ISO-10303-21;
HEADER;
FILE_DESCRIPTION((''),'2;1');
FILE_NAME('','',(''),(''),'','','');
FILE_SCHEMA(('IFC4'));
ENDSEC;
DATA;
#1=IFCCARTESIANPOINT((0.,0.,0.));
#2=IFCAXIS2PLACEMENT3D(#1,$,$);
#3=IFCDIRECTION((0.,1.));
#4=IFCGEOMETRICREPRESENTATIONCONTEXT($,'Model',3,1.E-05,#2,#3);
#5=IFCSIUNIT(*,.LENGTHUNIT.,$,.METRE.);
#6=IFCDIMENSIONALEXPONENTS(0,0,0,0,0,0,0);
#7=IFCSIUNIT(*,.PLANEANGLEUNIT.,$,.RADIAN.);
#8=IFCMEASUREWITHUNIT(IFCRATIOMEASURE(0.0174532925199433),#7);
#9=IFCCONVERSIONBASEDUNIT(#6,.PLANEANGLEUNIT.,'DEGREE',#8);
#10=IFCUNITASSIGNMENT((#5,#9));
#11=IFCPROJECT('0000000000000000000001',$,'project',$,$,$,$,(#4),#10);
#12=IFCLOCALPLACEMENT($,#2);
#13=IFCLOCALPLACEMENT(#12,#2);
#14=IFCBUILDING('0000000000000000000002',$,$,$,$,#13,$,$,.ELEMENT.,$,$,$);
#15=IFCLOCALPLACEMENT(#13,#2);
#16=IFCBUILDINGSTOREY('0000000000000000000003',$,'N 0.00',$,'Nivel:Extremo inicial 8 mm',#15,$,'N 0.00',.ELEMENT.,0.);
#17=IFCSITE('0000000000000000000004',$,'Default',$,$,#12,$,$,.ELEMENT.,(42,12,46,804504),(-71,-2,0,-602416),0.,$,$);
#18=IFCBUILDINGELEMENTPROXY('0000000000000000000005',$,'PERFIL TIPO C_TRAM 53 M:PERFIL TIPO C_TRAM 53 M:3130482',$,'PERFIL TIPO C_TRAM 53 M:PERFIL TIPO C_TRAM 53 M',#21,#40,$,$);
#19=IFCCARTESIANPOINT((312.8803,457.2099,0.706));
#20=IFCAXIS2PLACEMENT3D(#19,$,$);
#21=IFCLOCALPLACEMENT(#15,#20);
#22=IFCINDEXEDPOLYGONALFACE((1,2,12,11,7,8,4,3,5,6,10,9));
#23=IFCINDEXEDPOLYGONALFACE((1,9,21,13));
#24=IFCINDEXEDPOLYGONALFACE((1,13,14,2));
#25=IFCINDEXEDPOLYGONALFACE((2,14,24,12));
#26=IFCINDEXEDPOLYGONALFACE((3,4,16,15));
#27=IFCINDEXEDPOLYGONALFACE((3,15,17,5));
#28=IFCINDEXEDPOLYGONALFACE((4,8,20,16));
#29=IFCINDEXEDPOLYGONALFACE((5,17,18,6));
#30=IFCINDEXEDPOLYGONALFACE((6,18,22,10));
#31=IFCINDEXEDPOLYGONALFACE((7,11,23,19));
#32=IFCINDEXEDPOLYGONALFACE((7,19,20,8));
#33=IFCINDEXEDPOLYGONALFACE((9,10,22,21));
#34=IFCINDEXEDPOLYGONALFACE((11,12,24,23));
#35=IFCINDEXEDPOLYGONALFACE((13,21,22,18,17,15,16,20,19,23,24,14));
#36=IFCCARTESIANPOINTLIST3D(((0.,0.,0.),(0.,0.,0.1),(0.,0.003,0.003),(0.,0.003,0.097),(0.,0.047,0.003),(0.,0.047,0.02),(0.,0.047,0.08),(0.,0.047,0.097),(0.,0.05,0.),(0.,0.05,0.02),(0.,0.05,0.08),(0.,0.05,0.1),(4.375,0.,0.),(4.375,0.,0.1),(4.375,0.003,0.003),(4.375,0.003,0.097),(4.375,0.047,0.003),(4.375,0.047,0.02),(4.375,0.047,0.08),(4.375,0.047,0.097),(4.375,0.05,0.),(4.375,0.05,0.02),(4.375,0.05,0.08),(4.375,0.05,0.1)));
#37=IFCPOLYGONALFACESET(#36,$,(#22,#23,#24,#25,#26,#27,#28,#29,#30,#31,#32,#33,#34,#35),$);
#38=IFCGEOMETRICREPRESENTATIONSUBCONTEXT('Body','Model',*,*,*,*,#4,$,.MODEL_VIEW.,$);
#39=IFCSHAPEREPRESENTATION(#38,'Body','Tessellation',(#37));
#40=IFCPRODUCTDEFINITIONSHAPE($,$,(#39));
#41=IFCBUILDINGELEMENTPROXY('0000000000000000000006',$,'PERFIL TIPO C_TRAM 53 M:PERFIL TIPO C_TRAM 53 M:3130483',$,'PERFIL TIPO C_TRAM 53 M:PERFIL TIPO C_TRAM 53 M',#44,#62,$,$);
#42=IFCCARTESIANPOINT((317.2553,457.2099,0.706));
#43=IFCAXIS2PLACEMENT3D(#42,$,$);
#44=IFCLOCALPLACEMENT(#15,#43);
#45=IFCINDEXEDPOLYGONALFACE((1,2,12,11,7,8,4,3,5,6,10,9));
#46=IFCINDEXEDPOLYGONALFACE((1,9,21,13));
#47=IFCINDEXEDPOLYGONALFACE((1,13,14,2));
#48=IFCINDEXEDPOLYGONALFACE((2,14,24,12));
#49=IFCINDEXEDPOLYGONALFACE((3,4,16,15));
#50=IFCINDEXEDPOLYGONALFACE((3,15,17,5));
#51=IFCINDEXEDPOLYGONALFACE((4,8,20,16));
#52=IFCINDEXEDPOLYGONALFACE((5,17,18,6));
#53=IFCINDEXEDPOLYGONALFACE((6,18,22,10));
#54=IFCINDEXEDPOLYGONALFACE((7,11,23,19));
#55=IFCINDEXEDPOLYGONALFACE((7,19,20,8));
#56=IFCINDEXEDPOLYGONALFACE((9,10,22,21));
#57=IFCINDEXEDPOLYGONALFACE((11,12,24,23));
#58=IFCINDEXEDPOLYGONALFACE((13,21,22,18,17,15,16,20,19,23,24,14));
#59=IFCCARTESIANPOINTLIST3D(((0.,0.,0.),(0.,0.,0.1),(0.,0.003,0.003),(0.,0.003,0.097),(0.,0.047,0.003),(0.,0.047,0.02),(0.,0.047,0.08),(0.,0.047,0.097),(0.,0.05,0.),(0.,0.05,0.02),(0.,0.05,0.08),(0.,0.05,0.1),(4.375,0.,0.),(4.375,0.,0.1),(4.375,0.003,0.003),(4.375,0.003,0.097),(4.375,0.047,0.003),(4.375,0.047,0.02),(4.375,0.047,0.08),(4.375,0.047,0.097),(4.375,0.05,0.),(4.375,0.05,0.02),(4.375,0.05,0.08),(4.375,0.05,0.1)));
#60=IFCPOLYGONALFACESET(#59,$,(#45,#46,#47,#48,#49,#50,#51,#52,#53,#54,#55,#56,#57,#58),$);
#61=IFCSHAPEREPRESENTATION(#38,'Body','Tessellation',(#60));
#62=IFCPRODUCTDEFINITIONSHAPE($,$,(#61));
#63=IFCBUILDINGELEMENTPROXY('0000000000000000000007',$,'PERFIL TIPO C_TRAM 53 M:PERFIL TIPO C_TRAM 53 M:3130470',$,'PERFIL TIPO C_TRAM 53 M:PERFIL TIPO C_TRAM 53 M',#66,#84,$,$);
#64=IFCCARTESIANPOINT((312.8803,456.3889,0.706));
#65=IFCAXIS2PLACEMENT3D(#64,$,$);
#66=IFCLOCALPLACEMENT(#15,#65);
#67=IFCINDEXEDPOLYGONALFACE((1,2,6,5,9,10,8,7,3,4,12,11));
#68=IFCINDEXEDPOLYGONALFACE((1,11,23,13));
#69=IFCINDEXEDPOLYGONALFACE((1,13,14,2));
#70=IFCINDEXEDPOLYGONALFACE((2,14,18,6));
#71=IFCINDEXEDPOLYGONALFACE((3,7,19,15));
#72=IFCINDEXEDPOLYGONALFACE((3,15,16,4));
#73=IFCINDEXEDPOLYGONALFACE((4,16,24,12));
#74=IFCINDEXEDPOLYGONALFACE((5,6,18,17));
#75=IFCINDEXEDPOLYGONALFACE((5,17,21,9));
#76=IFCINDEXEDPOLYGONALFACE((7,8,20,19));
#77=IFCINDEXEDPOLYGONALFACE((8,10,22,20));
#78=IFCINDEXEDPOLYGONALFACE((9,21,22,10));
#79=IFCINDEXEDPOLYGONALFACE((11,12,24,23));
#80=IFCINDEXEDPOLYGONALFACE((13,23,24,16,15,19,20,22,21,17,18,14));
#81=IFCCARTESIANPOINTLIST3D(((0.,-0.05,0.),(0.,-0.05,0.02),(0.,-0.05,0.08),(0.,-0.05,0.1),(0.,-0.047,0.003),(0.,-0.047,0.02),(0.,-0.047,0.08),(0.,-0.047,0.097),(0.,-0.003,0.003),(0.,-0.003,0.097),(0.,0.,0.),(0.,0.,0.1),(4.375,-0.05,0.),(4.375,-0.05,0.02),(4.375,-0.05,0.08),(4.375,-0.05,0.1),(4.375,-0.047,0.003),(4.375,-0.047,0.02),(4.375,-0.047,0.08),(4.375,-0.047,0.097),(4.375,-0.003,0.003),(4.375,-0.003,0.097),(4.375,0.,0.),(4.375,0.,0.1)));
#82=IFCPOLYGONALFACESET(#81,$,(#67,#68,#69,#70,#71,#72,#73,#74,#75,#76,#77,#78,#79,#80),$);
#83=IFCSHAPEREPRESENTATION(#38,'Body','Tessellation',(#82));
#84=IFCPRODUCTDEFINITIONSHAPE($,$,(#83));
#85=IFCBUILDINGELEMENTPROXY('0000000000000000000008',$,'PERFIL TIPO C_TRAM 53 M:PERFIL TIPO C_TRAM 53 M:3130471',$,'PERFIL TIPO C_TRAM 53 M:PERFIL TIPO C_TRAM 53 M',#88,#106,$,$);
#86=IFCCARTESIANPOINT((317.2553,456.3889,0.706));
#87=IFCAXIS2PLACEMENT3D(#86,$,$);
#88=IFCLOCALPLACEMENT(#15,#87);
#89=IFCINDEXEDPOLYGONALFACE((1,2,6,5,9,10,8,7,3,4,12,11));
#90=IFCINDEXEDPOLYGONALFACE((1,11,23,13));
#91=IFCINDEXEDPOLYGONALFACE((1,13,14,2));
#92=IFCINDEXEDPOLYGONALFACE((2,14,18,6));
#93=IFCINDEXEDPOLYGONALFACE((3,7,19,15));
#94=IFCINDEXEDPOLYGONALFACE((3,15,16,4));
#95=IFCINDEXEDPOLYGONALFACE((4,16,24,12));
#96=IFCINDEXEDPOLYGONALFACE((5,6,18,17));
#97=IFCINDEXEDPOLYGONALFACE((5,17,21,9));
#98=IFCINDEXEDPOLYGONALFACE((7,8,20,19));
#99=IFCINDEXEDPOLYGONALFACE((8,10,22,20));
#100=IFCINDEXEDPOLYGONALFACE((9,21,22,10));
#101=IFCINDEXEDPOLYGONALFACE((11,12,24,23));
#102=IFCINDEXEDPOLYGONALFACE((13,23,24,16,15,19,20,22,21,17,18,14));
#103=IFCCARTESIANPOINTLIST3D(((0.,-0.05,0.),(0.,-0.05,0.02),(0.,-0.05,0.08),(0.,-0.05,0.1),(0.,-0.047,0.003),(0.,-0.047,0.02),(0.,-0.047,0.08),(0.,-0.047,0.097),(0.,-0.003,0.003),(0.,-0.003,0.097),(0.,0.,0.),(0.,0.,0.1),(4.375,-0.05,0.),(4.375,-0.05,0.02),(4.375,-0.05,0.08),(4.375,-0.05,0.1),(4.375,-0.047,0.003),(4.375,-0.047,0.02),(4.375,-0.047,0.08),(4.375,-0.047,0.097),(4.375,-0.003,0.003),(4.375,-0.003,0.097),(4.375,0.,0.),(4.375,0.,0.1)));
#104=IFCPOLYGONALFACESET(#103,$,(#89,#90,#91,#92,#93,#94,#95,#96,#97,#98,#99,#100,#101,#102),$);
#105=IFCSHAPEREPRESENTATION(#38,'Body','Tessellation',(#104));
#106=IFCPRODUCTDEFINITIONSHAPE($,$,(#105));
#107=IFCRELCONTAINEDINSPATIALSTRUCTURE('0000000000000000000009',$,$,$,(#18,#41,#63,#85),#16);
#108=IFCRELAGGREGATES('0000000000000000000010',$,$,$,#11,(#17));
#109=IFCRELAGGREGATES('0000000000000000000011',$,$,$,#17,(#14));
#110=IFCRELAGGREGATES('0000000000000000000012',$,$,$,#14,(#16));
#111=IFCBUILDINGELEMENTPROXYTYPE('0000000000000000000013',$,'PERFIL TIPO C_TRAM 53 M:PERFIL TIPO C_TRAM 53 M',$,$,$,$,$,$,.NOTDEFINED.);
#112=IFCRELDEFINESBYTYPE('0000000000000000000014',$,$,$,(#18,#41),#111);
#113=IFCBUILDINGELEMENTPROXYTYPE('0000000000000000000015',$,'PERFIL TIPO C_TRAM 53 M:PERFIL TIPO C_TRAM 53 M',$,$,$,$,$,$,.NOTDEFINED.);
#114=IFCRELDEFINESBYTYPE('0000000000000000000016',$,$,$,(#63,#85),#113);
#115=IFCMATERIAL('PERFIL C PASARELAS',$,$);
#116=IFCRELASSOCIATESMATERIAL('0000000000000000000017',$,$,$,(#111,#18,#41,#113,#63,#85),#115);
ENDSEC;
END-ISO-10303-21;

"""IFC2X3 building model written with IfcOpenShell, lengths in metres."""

from ifc_helpers import new_model, entity, si_unit, converted_unit, direction, frame, origin, place, context, subcontext, project, spatial, polyline, outline, extrude, source, transform, mapped, material, type_object, type_shapes, element, save


model = new_model("IFC2X3")

# Units and contexts
model_context = context("Model", 3, precision=1e-05, world=origin(), true_north=direction((0.0, 1.0)))
body_context = subcontext(model_context, "Body", "Model", "MODEL_VIEW")
ifc_project = project(units=[si_unit("LENGTHUNIT", "METRE"), converted_unit("PLANEANGLEUNIT", "DEGREE", entity("IfcRatioMeasure", 0.0174532925199433), si_unit("PLANEANGLEUNIT", "RADIAN"), dimensions=[0, 0, 0, 0, 0, 0, 0])], contexts=[model_context])

# Site, building, storey
site_placement = place(None, origin())
site = spatial("IfcSite", under=ifc_project, at=site_placement, Name="Default", CompositionType="ELEMENT", RefLatitude=(42, 12, 46, 804504), RefLongitude=(-71, -2, 0, -602416), RefElevation=0.0)
building_placement = place(site_placement, origin())
building = spatial("IfcBuilding", under=site, at=building_placement, CompositionType="ELEMENT")
storey_placement = place(building_placement, origin())
storey = spatial("IfcBuildingStorey", under=building, at=storey_placement, Name="N 0.00", ObjectType="Nivel:Extremo inicial 8 mm", LongName="N 0.00", CompositionType="ELEMENT", Elevation=0.0)

# Building element proxies
ifc_material_1 = material(Name="PERFIL C PASARELAS")
building_element_proxy_type_1 = type_object("IfcBuildingElementProxyType", Name="PERFIL TIPO C_TRAM 53 M:PERFIL TIPO C_TRAM 53 M", PredefinedType="NOTDEFINED", material=ifc_material_1)
shared_shape_1 = source(origin(), body_context, "Body", "SweptSolid", [
    extrude(outline(polyline([(-0.0172, 0.03), (-0.0142, 0.03), (-0.0142, 0.047), (0.0298, 0.047), (0.0298, -0.047), (-0.0142, -0.047), (-0.0142, -0.03), (-0.0172, -0.03), (-0.0172, -0.05), (0.0328, -0.05), (0.0328, 0.05), (-0.0172, 0.05), (-0.0172, 0.03)])), frame((0.0, 0.0328, 0.05), z_axis=(1.0, 0.0, 0.0), x_axis=(0.0, -1.0, 0.0)), (0.0, 0.0, 1.0), 4.375),
])
type_shapes(building_element_proxy_type_1, [shared_shape_1])
for number, where, name in (
    (1, (312.8803, 457.2099, 0.706), "PERFIL TIPO C_TRAM 53 M:PERFIL TIPO C_TRAM 53 M:3130482"),
    (2, (317.2553, 457.2099, 0.706), "PERFIL TIPO C_TRAM 53 M:PERFIL TIPO C_TRAM 53 M:3130483"),
):
    element("IfcBuildingElementProxy", number, at=place(storey_placement, frame(where)), inside=storey, type_object=building_element_proxy_type_1, material=ifc_material_1, Name=name, ObjectType="PERFIL TIPO C_TRAM 53 M:PERFIL TIPO C_TRAM 53 M", context=body_context, shape_type="MappedRepresentation", body=[
        mapped(shared_shape_1, transform((0.0, 0.0, 0.0), scale=1.0)),
    ])
building_element_proxy_type_2 = type_object("IfcBuildingElementProxyType", Name="PERFIL TIPO C_TRAM 53 M:PERFIL TIPO C_TRAM 53 M", PredefinedType="NOTDEFINED", material=ifc_material_1)
shared_shape_2 = source(origin(), body_context, "Body", "SweptSolid", [
    extrude(outline(polyline([(0.03, -0.0172), (0.05, -0.0172), (0.05, 0.0328), (-0.05, 0.0328), (-0.05, -0.0172), (-0.03, -0.0172), (-0.03, -0.0142), (-0.047, -0.0142), (-0.047, 0.0298), (0.047, 0.0298), (0.047, -0.0142), (0.03, -0.0142), (0.03, -0.0172)])), frame((0.0, -0.0328, 0.05), z_axis=(1.0, 0.0, 0.0), x_axis=(0.0, 0.0, -1.0)), (0.0, 0.0, 1.0), 4.375),
])
type_shapes(building_element_proxy_type_2, [shared_shape_2])
for number, where, name in (
    (3, (312.8803, 456.3889, 0.706), "PERFIL TIPO C_TRAM 53 M:PERFIL TIPO C_TRAM 53 M:3130470"),
    (4, (317.2553, 456.3889, 0.706), "PERFIL TIPO C_TRAM 53 M:PERFIL TIPO C_TRAM 53 M:3130471"),
):
    element("IfcBuildingElementProxy", number, at=place(storey_placement, frame(where)), inside=storey, type_object=building_element_proxy_type_2, material=ifc_material_1, Name=name, ObjectType="PERFIL TIPO C_TRAM 53 M:PERFIL TIPO C_TRAM 53 M", context=body_context, shape_type="MappedRepresentation", body=[
        mapped(shared_shape_2, transform((0.0, 0.0, 0.0), scale=1.0)),
    ])

save(model, "model.ifc")
